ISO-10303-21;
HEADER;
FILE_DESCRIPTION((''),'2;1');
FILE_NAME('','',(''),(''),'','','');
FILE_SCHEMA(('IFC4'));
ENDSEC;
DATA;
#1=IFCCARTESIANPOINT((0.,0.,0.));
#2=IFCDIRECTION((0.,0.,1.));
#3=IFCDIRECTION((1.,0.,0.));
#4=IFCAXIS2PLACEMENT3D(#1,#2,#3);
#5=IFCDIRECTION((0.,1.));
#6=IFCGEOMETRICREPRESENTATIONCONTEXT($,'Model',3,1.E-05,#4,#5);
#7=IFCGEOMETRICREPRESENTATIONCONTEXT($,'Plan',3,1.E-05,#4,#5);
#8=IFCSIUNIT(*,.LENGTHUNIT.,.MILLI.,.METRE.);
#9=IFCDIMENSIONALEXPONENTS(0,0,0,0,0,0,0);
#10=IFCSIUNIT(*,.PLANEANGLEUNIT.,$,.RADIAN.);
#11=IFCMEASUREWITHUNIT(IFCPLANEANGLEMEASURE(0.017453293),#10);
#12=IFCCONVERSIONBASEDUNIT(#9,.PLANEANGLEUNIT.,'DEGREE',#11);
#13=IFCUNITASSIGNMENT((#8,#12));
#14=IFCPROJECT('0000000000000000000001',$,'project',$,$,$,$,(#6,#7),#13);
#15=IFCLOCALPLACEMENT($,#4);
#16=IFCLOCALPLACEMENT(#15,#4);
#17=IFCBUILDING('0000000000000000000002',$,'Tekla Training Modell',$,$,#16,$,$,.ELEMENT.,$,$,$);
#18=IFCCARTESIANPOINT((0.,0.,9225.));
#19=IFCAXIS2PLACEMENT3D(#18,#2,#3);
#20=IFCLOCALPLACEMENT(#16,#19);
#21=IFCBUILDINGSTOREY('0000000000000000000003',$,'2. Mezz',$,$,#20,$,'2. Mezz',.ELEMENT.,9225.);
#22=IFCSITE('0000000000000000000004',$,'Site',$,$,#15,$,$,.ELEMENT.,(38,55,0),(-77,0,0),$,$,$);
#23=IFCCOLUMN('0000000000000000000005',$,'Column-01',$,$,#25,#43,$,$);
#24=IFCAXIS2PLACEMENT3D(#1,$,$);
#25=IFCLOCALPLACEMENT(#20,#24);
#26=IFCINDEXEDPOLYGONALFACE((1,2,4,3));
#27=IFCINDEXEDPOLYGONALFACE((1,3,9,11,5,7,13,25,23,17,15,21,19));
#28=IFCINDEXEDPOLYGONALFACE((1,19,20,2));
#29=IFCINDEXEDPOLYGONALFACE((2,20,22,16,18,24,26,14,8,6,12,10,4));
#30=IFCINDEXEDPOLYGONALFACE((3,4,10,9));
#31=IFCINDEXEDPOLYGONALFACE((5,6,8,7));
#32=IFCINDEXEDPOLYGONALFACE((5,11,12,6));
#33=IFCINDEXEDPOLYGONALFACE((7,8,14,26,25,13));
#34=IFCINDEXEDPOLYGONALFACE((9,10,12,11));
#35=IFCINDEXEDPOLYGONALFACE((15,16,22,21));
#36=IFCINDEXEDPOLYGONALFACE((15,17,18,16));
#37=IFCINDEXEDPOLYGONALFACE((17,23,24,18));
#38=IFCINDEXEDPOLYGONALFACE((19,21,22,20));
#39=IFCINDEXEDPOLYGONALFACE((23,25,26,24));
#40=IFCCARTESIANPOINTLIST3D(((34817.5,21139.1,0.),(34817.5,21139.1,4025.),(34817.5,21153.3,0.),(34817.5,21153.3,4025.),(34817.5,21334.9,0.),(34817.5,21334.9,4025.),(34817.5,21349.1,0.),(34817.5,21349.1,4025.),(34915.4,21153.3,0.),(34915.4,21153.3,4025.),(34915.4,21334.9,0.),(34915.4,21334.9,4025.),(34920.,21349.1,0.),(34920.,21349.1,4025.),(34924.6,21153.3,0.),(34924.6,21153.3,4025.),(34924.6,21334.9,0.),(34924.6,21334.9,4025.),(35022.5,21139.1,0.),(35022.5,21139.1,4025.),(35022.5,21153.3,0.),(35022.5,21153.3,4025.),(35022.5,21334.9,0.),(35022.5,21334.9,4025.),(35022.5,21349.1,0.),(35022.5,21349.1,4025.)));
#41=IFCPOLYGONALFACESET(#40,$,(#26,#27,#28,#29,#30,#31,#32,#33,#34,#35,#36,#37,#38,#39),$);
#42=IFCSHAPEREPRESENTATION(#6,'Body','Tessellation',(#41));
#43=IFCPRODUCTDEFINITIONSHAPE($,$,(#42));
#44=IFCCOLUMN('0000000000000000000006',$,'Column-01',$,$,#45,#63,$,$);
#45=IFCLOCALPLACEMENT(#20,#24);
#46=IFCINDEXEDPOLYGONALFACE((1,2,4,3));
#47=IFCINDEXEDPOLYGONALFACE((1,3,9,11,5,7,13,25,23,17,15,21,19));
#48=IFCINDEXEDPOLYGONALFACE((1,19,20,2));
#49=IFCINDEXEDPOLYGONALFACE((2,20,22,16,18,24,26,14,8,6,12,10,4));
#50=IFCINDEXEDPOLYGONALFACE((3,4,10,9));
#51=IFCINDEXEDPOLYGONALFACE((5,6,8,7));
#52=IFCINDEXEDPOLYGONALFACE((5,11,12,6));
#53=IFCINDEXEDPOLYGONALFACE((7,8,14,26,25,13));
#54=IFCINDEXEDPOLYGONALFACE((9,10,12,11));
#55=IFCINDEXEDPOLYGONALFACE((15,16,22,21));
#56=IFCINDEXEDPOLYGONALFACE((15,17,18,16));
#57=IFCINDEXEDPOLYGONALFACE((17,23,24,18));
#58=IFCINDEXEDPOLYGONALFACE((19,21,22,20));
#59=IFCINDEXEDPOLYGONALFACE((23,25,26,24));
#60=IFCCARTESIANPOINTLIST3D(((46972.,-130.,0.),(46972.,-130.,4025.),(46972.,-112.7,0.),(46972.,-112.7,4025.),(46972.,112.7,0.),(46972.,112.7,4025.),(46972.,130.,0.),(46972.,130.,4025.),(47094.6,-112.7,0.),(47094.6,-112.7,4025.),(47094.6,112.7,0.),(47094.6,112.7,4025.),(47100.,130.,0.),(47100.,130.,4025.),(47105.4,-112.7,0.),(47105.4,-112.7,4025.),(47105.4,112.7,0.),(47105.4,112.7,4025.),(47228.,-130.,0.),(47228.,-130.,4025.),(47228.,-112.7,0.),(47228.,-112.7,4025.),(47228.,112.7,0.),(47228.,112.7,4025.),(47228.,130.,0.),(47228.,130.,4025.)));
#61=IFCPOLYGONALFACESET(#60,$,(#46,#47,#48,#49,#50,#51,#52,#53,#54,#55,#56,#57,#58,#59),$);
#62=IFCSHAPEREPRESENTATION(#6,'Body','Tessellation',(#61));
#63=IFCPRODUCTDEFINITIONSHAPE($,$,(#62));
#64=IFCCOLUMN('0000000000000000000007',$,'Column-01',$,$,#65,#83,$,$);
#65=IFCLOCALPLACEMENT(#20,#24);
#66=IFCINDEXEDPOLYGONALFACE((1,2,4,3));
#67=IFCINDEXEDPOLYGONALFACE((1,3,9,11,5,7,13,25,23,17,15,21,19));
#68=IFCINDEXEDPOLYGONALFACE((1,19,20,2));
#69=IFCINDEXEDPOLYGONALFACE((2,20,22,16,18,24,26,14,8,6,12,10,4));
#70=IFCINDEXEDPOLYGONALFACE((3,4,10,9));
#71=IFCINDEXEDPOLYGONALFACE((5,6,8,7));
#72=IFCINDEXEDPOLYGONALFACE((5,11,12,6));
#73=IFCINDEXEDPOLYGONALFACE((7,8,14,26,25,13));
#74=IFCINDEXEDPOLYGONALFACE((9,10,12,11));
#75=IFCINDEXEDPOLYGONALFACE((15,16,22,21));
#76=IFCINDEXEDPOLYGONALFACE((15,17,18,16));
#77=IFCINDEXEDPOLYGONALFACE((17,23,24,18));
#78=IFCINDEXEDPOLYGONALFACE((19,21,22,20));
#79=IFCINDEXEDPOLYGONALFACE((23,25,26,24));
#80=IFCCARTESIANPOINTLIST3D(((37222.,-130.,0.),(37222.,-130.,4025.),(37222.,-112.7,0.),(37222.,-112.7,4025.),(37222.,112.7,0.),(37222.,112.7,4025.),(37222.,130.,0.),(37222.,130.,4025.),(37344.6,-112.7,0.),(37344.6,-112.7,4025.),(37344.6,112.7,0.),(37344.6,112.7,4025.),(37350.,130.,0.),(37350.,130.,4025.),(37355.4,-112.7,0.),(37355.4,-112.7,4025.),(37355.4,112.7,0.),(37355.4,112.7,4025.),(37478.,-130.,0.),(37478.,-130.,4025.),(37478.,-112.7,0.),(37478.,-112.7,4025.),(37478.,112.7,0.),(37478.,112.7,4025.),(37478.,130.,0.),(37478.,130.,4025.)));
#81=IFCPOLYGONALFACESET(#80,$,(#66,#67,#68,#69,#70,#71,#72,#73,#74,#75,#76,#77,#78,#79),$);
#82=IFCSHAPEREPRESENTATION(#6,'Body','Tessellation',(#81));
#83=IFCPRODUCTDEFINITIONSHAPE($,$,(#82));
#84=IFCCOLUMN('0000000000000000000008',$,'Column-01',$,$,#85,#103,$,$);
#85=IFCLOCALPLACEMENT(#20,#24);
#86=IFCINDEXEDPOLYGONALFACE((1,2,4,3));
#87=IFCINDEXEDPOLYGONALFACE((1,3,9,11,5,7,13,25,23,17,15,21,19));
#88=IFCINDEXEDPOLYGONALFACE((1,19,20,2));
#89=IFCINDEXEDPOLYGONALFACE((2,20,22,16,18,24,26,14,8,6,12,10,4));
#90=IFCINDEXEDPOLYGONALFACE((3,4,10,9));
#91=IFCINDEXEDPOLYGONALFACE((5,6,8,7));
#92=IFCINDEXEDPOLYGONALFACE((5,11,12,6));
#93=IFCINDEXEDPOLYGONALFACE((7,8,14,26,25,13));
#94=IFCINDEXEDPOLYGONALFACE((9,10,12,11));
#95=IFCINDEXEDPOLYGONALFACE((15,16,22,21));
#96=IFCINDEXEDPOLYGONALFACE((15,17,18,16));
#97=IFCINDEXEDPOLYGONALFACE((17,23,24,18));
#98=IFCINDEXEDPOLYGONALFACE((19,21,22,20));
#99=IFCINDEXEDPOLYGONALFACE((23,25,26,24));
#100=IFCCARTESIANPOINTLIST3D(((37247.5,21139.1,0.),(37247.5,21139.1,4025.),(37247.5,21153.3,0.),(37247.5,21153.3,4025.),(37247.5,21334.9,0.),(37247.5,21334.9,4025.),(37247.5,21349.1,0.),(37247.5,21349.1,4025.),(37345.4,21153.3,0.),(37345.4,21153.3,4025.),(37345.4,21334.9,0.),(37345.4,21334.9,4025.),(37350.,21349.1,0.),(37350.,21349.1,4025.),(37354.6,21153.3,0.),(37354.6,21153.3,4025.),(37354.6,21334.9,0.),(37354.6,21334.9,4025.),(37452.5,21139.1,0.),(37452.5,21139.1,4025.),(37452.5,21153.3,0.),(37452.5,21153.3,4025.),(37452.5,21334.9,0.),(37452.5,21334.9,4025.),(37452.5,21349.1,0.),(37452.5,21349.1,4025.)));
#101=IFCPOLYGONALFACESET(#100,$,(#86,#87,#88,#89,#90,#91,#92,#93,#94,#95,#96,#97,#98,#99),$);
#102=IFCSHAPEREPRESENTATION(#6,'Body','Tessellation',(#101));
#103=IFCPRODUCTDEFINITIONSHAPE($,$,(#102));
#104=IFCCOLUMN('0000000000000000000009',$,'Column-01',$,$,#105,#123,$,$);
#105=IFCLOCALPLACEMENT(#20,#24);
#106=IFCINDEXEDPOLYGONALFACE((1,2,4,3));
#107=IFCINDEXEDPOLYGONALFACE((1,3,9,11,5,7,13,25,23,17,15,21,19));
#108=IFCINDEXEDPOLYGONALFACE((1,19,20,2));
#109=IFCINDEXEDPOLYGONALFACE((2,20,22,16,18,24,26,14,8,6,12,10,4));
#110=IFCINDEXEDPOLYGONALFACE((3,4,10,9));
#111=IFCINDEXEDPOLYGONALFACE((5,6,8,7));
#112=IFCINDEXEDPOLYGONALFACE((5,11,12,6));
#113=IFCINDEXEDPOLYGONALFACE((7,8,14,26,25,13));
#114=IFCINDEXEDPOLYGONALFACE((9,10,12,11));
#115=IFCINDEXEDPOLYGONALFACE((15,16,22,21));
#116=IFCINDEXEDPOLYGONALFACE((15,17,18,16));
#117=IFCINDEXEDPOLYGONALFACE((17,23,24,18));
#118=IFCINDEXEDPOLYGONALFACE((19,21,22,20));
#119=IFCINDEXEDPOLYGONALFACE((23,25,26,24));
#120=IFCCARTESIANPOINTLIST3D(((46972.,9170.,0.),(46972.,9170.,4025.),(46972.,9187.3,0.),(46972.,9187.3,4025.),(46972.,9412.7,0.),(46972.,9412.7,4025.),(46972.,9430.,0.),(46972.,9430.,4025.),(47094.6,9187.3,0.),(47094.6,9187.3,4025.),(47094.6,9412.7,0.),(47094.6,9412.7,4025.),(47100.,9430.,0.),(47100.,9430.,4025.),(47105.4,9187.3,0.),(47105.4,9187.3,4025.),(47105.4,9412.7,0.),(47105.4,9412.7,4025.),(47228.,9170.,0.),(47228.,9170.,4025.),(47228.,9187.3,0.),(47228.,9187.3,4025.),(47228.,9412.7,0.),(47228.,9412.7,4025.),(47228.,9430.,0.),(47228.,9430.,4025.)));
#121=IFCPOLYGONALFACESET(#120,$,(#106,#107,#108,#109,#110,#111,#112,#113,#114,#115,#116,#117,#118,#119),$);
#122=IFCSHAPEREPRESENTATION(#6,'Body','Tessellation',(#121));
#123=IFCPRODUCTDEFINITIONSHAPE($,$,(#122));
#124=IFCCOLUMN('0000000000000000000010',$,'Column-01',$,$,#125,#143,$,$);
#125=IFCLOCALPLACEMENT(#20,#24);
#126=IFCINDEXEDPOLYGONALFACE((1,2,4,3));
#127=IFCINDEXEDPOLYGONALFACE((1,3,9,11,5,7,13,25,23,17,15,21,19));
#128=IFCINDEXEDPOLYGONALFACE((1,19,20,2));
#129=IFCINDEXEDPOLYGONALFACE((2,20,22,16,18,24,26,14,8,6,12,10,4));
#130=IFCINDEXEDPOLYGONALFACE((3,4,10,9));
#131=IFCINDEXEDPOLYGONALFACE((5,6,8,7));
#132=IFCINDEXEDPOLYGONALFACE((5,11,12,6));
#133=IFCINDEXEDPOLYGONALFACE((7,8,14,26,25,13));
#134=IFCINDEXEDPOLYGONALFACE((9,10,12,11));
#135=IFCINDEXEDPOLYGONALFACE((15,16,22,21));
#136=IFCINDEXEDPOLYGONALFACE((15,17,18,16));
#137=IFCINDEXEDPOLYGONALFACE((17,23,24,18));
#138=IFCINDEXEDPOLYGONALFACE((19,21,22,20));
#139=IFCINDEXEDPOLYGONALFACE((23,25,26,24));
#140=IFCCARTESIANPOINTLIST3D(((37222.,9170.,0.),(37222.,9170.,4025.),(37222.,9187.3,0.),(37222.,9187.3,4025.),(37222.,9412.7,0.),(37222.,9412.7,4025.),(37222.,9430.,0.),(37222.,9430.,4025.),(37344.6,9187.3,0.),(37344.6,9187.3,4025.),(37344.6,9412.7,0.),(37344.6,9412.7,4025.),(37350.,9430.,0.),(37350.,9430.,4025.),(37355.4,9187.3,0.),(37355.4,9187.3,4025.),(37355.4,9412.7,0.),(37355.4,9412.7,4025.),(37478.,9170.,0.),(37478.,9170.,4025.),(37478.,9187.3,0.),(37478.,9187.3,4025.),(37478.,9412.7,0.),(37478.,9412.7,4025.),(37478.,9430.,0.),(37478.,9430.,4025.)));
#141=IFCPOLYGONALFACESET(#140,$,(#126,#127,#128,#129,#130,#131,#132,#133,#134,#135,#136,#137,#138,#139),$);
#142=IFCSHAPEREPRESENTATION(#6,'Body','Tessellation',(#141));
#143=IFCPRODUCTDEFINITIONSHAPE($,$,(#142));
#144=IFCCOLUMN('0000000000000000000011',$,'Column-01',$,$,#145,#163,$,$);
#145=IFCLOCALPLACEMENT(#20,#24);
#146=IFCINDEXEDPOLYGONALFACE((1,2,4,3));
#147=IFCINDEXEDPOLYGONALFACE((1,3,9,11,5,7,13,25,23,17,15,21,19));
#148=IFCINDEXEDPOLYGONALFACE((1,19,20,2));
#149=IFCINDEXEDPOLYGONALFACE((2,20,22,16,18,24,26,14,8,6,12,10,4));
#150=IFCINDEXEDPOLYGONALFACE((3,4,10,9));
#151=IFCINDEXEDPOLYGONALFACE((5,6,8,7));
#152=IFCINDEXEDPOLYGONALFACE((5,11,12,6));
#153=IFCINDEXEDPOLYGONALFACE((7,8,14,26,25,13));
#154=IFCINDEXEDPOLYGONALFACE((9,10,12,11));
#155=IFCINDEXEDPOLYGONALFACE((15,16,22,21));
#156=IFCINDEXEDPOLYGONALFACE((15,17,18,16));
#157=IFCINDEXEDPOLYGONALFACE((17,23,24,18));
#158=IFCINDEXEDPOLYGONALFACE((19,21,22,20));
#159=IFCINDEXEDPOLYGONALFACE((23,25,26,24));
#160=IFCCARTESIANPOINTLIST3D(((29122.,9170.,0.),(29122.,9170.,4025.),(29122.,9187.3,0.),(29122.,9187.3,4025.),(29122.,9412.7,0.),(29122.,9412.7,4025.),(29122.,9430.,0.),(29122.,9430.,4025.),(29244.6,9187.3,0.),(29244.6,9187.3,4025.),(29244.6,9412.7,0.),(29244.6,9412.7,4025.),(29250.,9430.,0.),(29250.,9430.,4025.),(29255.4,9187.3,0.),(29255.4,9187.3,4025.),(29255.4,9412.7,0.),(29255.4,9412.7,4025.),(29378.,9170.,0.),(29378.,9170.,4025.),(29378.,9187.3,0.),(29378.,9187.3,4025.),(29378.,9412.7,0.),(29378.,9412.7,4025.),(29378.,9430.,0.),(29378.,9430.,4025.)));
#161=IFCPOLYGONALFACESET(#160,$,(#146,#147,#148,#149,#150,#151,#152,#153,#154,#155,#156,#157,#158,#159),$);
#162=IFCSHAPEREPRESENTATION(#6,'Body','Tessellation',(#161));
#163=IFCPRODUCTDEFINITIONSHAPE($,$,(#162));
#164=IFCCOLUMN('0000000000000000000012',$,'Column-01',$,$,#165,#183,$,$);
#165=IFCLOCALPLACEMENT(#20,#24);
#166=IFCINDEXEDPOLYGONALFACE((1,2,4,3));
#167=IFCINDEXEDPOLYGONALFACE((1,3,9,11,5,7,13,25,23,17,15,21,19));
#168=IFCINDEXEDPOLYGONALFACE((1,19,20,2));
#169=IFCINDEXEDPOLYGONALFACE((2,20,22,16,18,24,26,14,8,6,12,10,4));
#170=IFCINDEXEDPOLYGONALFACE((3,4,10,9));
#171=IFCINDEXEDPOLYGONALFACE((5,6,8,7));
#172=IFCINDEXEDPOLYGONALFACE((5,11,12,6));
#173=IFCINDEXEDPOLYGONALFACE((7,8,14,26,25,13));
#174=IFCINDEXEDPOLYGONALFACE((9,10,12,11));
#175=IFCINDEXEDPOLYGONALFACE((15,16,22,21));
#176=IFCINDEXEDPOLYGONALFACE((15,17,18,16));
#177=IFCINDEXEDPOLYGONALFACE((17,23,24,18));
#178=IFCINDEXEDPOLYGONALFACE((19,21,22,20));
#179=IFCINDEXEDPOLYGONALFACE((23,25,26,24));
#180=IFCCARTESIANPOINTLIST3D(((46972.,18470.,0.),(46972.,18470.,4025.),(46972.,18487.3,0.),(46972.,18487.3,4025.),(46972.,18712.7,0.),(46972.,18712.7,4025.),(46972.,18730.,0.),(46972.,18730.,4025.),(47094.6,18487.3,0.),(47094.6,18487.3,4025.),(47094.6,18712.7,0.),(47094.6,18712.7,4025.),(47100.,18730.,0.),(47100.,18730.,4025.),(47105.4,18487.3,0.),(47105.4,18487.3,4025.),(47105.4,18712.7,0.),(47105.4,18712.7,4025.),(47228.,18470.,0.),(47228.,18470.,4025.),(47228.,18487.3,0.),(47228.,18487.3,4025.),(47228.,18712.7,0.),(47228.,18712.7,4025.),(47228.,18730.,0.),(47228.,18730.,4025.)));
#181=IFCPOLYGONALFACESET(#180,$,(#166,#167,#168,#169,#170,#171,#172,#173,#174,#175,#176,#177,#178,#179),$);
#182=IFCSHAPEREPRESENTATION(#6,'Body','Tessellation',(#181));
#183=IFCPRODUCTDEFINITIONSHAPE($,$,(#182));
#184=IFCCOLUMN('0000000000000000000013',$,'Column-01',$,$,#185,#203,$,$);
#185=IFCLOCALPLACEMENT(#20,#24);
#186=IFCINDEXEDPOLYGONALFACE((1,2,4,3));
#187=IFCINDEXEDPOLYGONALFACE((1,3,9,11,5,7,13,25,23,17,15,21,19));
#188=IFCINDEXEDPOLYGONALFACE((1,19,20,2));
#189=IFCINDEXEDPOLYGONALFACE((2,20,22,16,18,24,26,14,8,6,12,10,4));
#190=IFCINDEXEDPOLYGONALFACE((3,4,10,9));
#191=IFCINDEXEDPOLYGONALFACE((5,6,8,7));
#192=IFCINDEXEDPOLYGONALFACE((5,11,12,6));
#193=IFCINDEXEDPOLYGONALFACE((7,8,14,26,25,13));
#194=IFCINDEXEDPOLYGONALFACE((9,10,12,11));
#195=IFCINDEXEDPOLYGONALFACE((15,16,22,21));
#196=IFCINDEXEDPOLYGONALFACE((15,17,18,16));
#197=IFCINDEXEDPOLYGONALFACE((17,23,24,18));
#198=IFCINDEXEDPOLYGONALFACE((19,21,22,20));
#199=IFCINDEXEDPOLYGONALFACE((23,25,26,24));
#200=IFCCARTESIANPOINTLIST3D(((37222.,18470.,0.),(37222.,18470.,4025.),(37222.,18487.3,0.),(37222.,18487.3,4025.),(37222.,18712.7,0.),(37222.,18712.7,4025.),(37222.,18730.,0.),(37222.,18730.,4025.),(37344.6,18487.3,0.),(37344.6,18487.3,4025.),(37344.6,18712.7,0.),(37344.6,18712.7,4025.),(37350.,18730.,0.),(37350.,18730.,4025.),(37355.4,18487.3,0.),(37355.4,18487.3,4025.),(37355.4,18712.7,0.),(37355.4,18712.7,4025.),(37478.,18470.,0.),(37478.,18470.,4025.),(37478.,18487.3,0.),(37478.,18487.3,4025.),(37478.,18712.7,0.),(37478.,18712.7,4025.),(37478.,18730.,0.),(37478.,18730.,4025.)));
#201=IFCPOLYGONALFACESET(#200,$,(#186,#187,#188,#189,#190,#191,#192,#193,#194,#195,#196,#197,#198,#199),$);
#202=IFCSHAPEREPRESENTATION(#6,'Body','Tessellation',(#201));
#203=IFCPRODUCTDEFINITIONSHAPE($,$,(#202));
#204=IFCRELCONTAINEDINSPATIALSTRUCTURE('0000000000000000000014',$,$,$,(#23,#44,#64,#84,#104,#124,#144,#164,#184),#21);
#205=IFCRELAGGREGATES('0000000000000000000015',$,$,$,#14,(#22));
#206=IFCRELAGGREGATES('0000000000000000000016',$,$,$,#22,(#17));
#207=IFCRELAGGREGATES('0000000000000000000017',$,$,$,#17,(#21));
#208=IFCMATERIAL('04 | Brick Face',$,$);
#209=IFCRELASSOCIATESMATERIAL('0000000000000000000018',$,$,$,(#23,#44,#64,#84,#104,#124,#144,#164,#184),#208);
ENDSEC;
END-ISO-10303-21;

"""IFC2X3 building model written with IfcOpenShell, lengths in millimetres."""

from ifc_helpers import new_model, entity, si_unit, converted_unit, direction, frame, origin_with_axes, place, context, project, spatial, polyline, outline, extrude, material, element, save


model = new_model("IFC2X3")

# Units and contexts
model_context = context("Model", 3, precision=1e-05, world=origin_with_axes(), true_north=direction((0.0, 1.0)))
plan_context = context("Plan", 3, precision=1e-05, world=origin_with_axes(), true_north=direction((0.0, 1.0)))
ifc_project = project(units=[si_unit("LENGTHUNIT", "METRE", prefix="MILLI"), converted_unit("PLANEANGLEUNIT", "DEGREE", entity("IfcPlaneAngleMeasure", 0.017453293), si_unit("PLANEANGLEUNIT", "RADIAN"), dimensions=[0, 0, 0, 0, 0, 0, 0])], contexts=[model_context, plan_context])

# Site, building, storey
site_placement = place(None, origin_with_axes())
site = spatial("IfcSite", under=ifc_project, at=site_placement, Name="Site", CompositionType="ELEMENT", RefLatitude=(38, 55, 0), RefLongitude=(-77, 0, 0))
building_placement = place(site_placement, origin_with_axes())
building = spatial("IfcBuilding", under=site, at=building_placement, Name="Tekla Training Modell", CompositionType="ELEMENT")
storey_placement = place(building_placement, frame((0.0, 0.0, 9225.0), z_axis=(0.0, 0.0, 1.0), x_axis=(1.0, 0.0, 0.0)))
storey = spatial("IfcBuildingStorey", under=building, at=storey_placement, Name="2. Mezz", LongName="2. Mezz", CompositionType="ELEMENT", Elevation=9225.0)

# Columns
ifc_material_1 = material(Name="04 | Brick Face")
column_1_placement = place(storey_placement, frame((34920.0, 21244.1, 0.0), z_axis=(0.0, 0.0, 1.0), x_axis=(1.0, 0.0, 0.0)))
element("IfcColumn", 1, at=column_1_placement, inside=storey, material=ifc_material_1, Name="Column-01", context=model_context, shape_type="SweptSolid", body=[
    extrude(outline(polyline([(0.0, 105.0), (-102.5, 105.0), (-102.5, 90.8), (-4.5, 90.8), (-4.5, -90.8), (-102.5, -90.8), (-102.5, -105.0), (102.5, -105.0), (102.5, -90.8), (4.5, -90.8), (4.5, 90.8), (102.5, 90.8), (102.5, 105.0), (0.0, 105.0)])), origin_with_axes(), (0.0, 0.0, 1.0), 4025.0),
])
for number, where, z_axis, x_axis, name in (
    (2, (47100.0, 0.0, 0.0), (0.0, 0.0, 1.0), (1.0, 0.0, 0.0), "Column-01"),
    (3, (37350.0, 0.0, 0.0), (0.0, 0.0, 1.0), (1.0, 0.0, 0.0), "Column-01"),
):
    element("IfcColumn", number, at=place(storey_placement, frame(where, z_axis=z_axis, x_axis=x_axis)), inside=storey, material=ifc_material_1, Name=name, context=model_context, shape_type="SweptSolid", body=[
        extrude(outline(polyline([(0.0, 130.0), (-128.0, 130.0), (-128.0, 112.7), (-5.3, 112.7), (-5.3, -112.7), (-128.0, -112.7), (-128.0, -130.0), (128.0, -130.0), (128.0, -112.7), (5.3, -112.7), (5.3, 112.7), (128.0, 112.7), (128.0, 130.0), (0.0, 130.0)])), origin_with_axes(), (0.0, 0.0, 1.0), 4025.0),
    ])
column_2_placement = place(storey_placement, frame((37350.0, 21244.1, 0.0), z_axis=(0.0, 0.0, 1.0), x_axis=(1.0, 0.0, 0.0)))
element("IfcColumn", 4, at=column_2_placement, inside=storey, material=ifc_material_1, Name="Column-01", context=model_context, shape_type="SweptSolid", body=[
    extrude(outline(polyline([(0.0, 105.0), (-102.5, 105.0), (-102.5, 90.8), (-4.5, 90.8), (-4.5, -90.8), (-102.5, -90.8), (-102.5, -105.0), (102.5, -105.0), (102.5, -90.8), (4.5, -90.8), (4.5, 90.8), (102.5, 90.8), (102.5, 105.0), (0.0, 105.0)])), origin_with_axes(), (0.0, 0.0, 1.0), 4025.0),
])
for number, where, z_axis, x_axis, name in (
    (5, (47100.0, 9300.0, 0.0), (0.0, 0.0, 1.0), (1.0, 0.0, 0.0), "Column-01"),
    (6, (37350.0, 9300.0, 0.0), (0.0, 0.0, 1.0), (1.0, 0.0, 0.0), "Column-01"),
    (7, (29250.0, 9300.0, 0.0), (0.0, 0.0, 1.0), (1.0, 0.0, 0.0), "Column-01"),
    (8, (47100.0, 18600.0, 0.0), (0.0, 0.0, 1.0), (1.0, 0.0, 0.0), "Column-01"),
    (9, (37350.0, 18600.0, 0.0), (0.0, 0.0, 1.0), (1.0, 0.0, 0.0), "Column-01"),
):
    element("IfcColumn", number, at=place(storey_placement, frame(where, z_axis=z_axis, x_axis=x_axis)), inside=storey, material=ifc_material_1, Name=name, context=model_context, shape_type="SweptSolid", body=[
        extrude(outline(polyline([(0.0, 130.0), (-128.0, 130.0), (-128.0, 112.7), (-5.3, 112.7), (-5.3, -112.7), (-128.0, -112.7), (-128.0, -130.0), (128.0, -130.0), (128.0, -112.7), (5.3, -112.7), (5.3, 112.7), (128.0, 112.7), (128.0, 130.0), (0.0, 130.0)])), origin_with_axes(), (0.0, 0.0, 1.0), 4025.0),
    ])

save(model, "model.ifc")
